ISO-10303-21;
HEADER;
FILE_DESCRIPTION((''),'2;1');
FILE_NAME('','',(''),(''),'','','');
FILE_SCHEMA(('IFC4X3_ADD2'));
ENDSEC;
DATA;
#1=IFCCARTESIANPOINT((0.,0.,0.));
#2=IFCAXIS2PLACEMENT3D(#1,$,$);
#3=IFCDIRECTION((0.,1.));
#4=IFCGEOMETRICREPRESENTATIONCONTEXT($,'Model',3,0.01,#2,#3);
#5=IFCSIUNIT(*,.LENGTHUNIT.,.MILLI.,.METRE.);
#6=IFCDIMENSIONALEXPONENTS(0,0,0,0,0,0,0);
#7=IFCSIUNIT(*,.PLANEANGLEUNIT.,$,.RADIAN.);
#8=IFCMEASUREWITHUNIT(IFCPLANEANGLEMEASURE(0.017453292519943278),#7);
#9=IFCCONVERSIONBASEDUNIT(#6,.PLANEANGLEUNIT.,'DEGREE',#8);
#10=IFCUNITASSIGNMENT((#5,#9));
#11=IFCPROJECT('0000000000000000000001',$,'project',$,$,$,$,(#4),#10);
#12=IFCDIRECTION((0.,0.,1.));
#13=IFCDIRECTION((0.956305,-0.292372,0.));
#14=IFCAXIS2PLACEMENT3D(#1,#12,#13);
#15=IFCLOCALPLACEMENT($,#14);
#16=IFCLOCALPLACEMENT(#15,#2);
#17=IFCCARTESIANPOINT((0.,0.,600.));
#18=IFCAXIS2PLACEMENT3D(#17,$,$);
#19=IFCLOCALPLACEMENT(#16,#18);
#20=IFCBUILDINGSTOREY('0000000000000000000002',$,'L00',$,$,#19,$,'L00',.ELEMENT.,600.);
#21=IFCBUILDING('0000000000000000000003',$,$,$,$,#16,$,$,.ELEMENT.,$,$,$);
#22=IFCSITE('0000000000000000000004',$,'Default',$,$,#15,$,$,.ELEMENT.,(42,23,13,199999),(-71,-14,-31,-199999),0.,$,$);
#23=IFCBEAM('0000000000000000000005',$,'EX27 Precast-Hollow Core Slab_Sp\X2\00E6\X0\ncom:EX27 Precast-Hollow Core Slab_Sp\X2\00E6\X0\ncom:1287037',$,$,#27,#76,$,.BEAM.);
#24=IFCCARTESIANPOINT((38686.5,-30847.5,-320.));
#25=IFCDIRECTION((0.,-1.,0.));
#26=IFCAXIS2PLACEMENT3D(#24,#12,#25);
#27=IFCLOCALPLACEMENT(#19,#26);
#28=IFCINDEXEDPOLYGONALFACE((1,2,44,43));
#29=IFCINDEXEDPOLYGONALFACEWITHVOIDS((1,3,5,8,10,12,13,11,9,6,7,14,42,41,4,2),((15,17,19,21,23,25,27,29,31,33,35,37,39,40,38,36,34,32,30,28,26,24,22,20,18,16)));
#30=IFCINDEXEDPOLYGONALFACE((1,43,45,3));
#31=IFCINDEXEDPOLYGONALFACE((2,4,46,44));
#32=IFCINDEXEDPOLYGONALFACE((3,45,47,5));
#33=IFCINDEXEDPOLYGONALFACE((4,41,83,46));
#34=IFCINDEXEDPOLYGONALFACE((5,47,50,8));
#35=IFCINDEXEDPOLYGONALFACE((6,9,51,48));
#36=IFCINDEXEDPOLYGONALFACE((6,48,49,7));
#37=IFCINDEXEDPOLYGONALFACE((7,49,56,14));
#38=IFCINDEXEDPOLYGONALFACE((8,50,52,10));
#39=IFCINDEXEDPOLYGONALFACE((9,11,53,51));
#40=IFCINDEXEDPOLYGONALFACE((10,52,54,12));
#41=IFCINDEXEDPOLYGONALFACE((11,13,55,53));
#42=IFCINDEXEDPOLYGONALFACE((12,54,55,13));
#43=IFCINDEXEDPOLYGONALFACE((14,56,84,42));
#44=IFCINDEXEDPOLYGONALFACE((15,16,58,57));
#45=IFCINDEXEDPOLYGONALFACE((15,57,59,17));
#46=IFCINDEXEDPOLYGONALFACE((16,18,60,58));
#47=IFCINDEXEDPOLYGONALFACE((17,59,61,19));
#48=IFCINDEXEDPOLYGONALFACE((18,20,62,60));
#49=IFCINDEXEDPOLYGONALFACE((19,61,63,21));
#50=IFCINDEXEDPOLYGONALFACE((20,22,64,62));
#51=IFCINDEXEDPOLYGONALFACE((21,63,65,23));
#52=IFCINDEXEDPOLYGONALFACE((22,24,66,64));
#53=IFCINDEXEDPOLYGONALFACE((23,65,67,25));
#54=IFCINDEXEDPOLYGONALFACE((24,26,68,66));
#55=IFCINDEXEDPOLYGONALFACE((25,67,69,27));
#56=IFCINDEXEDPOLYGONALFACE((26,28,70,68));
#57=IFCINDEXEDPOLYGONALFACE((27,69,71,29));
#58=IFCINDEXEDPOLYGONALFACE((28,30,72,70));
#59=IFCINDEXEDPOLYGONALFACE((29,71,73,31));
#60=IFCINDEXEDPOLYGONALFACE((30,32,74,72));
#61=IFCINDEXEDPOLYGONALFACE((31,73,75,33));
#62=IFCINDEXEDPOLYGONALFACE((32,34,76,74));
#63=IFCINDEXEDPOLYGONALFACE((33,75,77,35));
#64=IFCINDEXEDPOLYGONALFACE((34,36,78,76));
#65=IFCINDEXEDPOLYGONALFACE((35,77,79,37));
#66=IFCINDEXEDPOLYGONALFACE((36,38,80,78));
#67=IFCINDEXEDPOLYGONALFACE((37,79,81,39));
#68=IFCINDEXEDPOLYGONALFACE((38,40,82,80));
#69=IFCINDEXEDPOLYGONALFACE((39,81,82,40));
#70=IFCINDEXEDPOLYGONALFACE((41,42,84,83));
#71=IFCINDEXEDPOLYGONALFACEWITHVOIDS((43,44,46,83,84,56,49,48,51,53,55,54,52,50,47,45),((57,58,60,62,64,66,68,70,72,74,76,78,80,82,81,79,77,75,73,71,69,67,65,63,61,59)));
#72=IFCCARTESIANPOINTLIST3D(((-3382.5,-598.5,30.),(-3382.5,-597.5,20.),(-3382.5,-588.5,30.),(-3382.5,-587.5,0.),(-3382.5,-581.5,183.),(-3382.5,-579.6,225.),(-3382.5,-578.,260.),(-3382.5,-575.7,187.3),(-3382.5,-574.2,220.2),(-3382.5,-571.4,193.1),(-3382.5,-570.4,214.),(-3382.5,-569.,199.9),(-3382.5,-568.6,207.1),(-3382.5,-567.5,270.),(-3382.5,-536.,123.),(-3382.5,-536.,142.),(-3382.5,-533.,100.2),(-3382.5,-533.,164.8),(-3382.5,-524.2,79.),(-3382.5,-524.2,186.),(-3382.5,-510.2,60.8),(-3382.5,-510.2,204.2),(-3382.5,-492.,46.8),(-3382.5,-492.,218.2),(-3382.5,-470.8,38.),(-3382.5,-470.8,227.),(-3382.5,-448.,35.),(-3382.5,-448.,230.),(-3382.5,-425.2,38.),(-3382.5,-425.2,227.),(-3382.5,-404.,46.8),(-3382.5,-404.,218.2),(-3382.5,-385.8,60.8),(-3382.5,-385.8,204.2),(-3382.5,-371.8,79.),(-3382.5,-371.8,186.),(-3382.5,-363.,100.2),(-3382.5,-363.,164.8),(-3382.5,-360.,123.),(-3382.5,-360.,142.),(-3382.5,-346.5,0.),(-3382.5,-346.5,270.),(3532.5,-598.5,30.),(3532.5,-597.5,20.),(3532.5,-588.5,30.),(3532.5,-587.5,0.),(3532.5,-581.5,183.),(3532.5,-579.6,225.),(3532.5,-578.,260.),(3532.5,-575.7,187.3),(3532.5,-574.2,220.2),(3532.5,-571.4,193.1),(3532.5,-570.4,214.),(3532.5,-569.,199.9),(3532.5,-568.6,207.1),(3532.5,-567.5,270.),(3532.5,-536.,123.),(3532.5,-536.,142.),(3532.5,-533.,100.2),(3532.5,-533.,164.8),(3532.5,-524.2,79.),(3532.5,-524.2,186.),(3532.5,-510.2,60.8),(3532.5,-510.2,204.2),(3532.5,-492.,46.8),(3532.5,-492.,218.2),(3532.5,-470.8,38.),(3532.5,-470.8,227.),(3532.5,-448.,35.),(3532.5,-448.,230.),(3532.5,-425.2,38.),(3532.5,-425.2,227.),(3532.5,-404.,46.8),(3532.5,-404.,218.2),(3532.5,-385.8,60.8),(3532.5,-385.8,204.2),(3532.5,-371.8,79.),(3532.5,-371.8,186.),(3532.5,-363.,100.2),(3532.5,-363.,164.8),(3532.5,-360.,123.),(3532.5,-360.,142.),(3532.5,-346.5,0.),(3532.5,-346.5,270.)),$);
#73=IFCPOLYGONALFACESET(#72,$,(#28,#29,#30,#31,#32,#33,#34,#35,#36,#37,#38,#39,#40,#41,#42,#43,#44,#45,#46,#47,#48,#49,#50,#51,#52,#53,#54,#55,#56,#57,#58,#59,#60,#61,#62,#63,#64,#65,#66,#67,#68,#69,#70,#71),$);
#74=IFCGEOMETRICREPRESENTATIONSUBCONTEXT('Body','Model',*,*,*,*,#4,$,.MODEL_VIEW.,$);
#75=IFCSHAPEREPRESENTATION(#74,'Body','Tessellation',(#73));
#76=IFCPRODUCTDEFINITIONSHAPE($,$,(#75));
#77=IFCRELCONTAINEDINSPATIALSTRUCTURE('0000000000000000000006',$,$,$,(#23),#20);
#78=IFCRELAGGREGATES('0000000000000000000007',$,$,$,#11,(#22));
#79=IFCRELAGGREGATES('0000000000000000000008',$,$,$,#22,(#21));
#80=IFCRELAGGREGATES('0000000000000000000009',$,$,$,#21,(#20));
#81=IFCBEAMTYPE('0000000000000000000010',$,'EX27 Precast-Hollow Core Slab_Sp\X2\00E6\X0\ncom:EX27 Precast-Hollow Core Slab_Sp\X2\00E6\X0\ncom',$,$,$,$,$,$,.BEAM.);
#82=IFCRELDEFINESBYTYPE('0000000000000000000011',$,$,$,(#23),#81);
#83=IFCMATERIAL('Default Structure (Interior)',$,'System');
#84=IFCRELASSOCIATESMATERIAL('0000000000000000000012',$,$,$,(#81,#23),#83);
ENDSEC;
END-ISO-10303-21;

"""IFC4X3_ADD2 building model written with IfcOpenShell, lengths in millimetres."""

from ifc_helpers import new_model, entity, si_unit, converted_unit, direction, frame, frame_2d, origin, place, context, subcontext, project, spatial, polyline, circle_curve, parameter, trimmed, segment, composite_curve, outline, extrude, source, transform, mapped, material, material_profile, profile_set, profile_usage, type_object, type_shapes, element, save


model = new_model("IFC4X3_ADD2")

# Units and contexts
model_context = context("Model", 3, precision=0.01, world=origin(), true_north=direction((0.0, 1.0)))
body_context = subcontext(model_context, "Body", "Model", "MODEL_VIEW")
ifc_project = project(units=[si_unit("LENGTHUNIT", "METRE", prefix="MILLI"), converted_unit("PLANEANGLEUNIT", "DEGREE", entity("IfcPlaneAngleMeasure", 0.017453292519943278), si_unit("PLANEANGLEUNIT", "RADIAN"), dimensions=[0, 0, 0, 0, 0, 0, 0])], contexts=[model_context])

# Site, building, storey
site_placement = place(None, frame((0.0, 0.0, 0.0), z_axis=(0.0, 0.0, 1.0), x_axis=(0.956305, -0.292372, 0.0)))
site = spatial("IfcSite", under=ifc_project, at=site_placement, Name="Default", CompositionType="ELEMENT", RefLatitude=(42, 23, 13, 199999), RefLongitude=(-71, -14, -31, -199999), RefElevation=0.0)
building_placement = place(site_placement, origin())
building = spatial("IfcBuilding", under=site, at=building_placement, CompositionType="ELEMENT")
storey_placement = place(building_placement, frame((0.0, 0.0, 600.0)))
storey = spatial("IfcBuildingStorey", under=building, at=storey_placement, Name="L00", LongName="L00", CompositionType="ELEMENT", Elevation=600.0)

# Beam
ifc_material_1 = material(Name="Default Structure (Interior)", Category="System")
ifc_material_profile_1 = material_profile(ifc_material_1, outline(composite_curve([segment(polyline([(-124.1, 583.4), (-124.6, 593.4)]), True, "CONTINUOUS"), segment(polyline([(-124.6, 593.4), (-134.5, 592.0)]), True, "CONTINUOUS"), segment(polyline([(-134.5, 592.0), (-154.0, 581.1)]), True, "CONTINUOUS"), segment(polyline([(-154.0, 581.1), (-100.2, -592.7)]), True, "CONTINUOUS"), segment(polyline([(-100.2, -592.7), (-79.8, -601.8)]), True, "CONTINUOUS"), segment(polyline([(-79.8, -601.8), (-69.7, -602.3)]), True, "CONTINUOUS"), segment(polyline([(-69.7, -602.3), (-70.2, -592.3)]), True, "CONTINUOUS"), segment(polyline([(-70.2, -592.3), (82.3, -578.3)]), True, "CONTINUOUS"), segment(trimmed(circle_curve(frame_2d((104.4, -588.8), x_axis=(0.045785, -0.998951)), 24.4), [parameter(123.160759)], [parameter(242.087681)], True, "PARAMETER"), False, "CONTINUOUS"), segment(polyline([(124.2, -574.5), (159.1, -571.3)]), True, "CONTINUOUS"), segment(polyline([(159.1, -571.3), (168.6, -560.4)]), True, "CONTINUOUS"), segment(polyline([(168.6, -560.4), (116.6, 573.4)]), True, "CONTINUOUS"), segment(polyline([(116.6, 573.4), (106.2, 583.4)]), True, "CONTINUOUS"), segment(polyline([(106.2, 583.4), (71.1, 583.4)]), True, "CONTINUOUS"), segment(trimmed(circle_curve(frame_2d((50.1, 595.8), x_axis=(0.045785, -0.998951)), 24.4), [parameter(297.912319)], [parameter(56.839241)], True, "PARAMETER"), False, "CONTINUOUS"), segment(polyline([(29.1, 583.4), (-124.1, 583.4)]), True, "CONTINUOUS")], self_intersect=False), holes=[composite_curve([segment(polyline([(39.3, -534.8), (20.3, -535.6)]), True, "CONTINUOUS"), segment(trimmed(circle_curve(frame_2d((16.3, -447.7), x_axis=(0.045785, -0.998951)), 88.0), [parameter(270.0)], [parameter(0.0)], True, "PARAMETER"), False, "CONTINUOUS"), segment(trimmed(circle_curve(frame_2d((16.3, -447.7), x_axis=(0.045785, -0.998951)), 88.0), [parameter(180.0)], [parameter(270.0)], True, "PARAMETER"), False, "CONTINUOUS"), segment(polyline([(12.2, -359.8), (31.2, -358.9)]), True, "CONTINUOUS"), segment(trimmed(circle_curve(frame_2d((35.2, -446.9), x_axis=(0.045785, -0.998951)), 88.0), [parameter(90.0)], [parameter(180.0)], True, "PARAMETER"), False, "CONTINUOUS"), segment(trimmed(circle_curve(frame_2d((35.2, -446.9), x_axis=(0.045785, -0.998951)), 88.0), [parameter(0.0)], [parameter(90.0)], True, "PARAMETER"), False, "CONTINUOUS")], self_intersect=False), composite_curve([segment(trimmed(circle_curve(frame_2d((6.0, -224.0), x_axis=(0.045785, -0.998951)), 88.0), [parameter(180.0)], [parameter(270.0)], True, "PARAMETER"), False, "CONTINUOUS"), segment(polyline([(2.0, -136.1), (21.0, -135.2)]), True, "CONTINUOUS"), segment(trimmed(circle_curve(frame_2d((25.0, -223.1), x_axis=(0.045785, -0.998951)), 88.0), [parameter(90.0)], [parameter(180.0)], True, "PARAMETER"), False, "CONTINUOUS"), segment(trimmed(circle_curve(frame_2d((25.0, -223.1), x_axis=(0.045785, -0.998951)), 88.0), [parameter(0.0)], [parameter(90.0)], True, "PARAMETER"), False, "CONTINUOUS"), segment(polyline([(29.0, -311.0), (10.0, -311.9)]), True, "CONTINUOUS"), segment(trimmed(circle_curve(frame_2d((6.0, -224.0), x_axis=(0.045785, -0.998951)), 88.0), [parameter(270.0)], [parameter(0.0)], True, "PARAMETER"), False, "CONTINUOUS")], self_intersect=False), composite_curve([segment(trimmed(circle_curve(frame_2d((-4.2, -0.2), x_axis=(0.045785, -0.998951)), 88.0), [parameter(180.0)], [parameter(270.0)], True, "PARAMETER"), False, "CONTINUOUS"), segment(polyline([(-8.3, 87.7), (10.7, 88.6)]), True, "CONTINUOUS"), segment(trimmed(circle_curve(frame_2d((14.7, 0.7), x_axis=(0.045785, -0.998951)), 88.0), [parameter(90.0)], [parameter(180.0)], True, "PARAMETER"), False, "CONTINUOUS"), segment(trimmed(circle_curve(frame_2d((14.7, 0.7), x_axis=(0.045785, -0.998951)), 88.0), [parameter(0.0)], [parameter(90.0)], True, "PARAMETER"), False, "CONTINUOUS"), segment(polyline([(18.8, -87.2), (-0.2, -88.1)]), True, "CONTINUOUS"), segment(trimmed(circle_curve(frame_2d((-4.2, -0.2), x_axis=(0.045785, -0.998951)), 88.0), [parameter(270.0)], [parameter(0.0)], True, "PARAMETER"), False, "CONTINUOUS")], self_intersect=False), composite_curve([segment(trimmed(circle_curve(frame_2d((-14.5, 223.6), x_axis=(0.045785, -0.998951)), 88.0), [parameter(180.0)], [parameter(270.0)], True, "PARAMETER"), False, "CONTINUOUS"), segment(polyline([(-18.5, 311.5), (0.4, 312.3)]), True, "CONTINUOUS"), segment(trimmed(circle_curve(frame_2d((4.5, 224.4), x_axis=(0.045785, -0.998951)), 88.0), [parameter(90.0)], [parameter(180.0)], True, "PARAMETER"), False, "CONTINUOUS"), segment(trimmed(circle_curve(frame_2d((4.5, 224.4), x_axis=(0.045785, -0.998951)), 88.0), [parameter(0.0)], [parameter(90.0)], True, "PARAMETER"), False, "CONTINUOUS"), segment(polyline([(8.5, 136.5), (-10.5, 135.7)]), True, "CONTINUOUS"), segment(trimmed(circle_curve(frame_2d((-14.5, 223.6), x_axis=(0.045785, -0.998951)), 88.0), [parameter(270.0)], [parameter(0.0)], True, "PARAMETER"), False, "CONTINUOUS")], self_intersect=False), composite_curve([segment(trimmed(circle_curve(frame_2d((-24.8, 447.3), x_axis=(0.045785, -0.998951)), 88.0), [parameter(180.0)], [parameter(270.0)], True, "PARAMETER"), False, "CONTINUOUS"), segment(polyline([(-28.8, 535.2), (-9.8, 536.1)]), True, "CONTINUOUS"), segment(trimmed(circle_curve(frame_2d((-5.8, 448.2), x_axis=(0.045785, -0.998951)), 88.0), [parameter(90.0)], [parameter(180.0)], True, "PARAMETER"), False, "CONTINUOUS"), segment(trimmed(circle_curve(frame_2d((-5.8, 448.2), x_axis=(0.045785, -0.998951)), 88.0), [parameter(0.0)], [parameter(90.0)], True, "PARAMETER"), False, "CONTINUOUS"), segment(polyline([(-1.7, 360.3), (-20.7, 359.4)]), True, "CONTINUOUS"), segment(trimmed(circle_curve(frame_2d((-24.8, 447.3), x_axis=(0.045785, -0.998951)), 88.0), [parameter(270.0)], [parameter(0.0)], True, "PARAMETER"), False, "CONTINUOUS")], self_intersect=False)]), Name="EX27 Precast-Hollow Core Slab_Spæncom")
ifc_profile_set_1 = profile_set([ifc_material_profile_1], Name="EX27 Precast-Hollow Core Slab_Spæncom")
ifc_profile_usage_1 = profile_usage(ifc_profile_set_1, cardinal=8)
beam_type_1 = type_object("IfcBeamType", Name="EX27 Precast-Hollow Core Slab_Spæncom:EX27 Precast-Hollow Core Slab_Spæncom", PredefinedType="BEAM", material=ifc_profile_set_1)
shared_shape_1 = source(origin(), body_context, "Body", "SweptSolid", [
    extrude(outline(composite_curve([segment(polyline([(-50.3, -128.8), (190.7, -128.8)]), True, "CONTINUOUS"), segment(polyline([(190.7, -128.8), (190.7, 141.2)]), True, "CONTINUOUS"), segment(polyline([(190.7, 141.2), (-30.3, 141.2)]), True, "CONTINUOUS"), segment(polyline([(-30.3, 141.2), (-40.8, 131.2)]), True, "CONTINUOUS"), segment(polyline([(-40.8, 131.2), (-42.4, 96.2)]), True, "CONTINUOUS"), segment(trimmed(circle_curve(frame_2d((-55.8, 75.8), x_axis=(-1.0, 0.0)), 24.4), [parameter(117.912319)], [parameter(236.839241)], True, "PARAMETER"), False, "CONTINUOUS"), segment(polyline([(-44.3, 54.2), (-51.3, -98.8)]), True, "CONTINUOUS"), segment(polyline([(-51.3, -98.8), (-61.3, -98.8)]), True, "CONTINUOUS"), segment(polyline([(-61.3, -98.8), (-60.3, -108.8)]), True, "CONTINUOUS"), segment(polyline([(-60.3, -108.8), (-50.3, -128.8)]), True, "CONTINUOUS")], self_intersect=False), holes=[composite_curve([segment(trimmed(circle_curve(frame_2d((89.2, 13.2), x_axis=(-1.0, 0.0)), 88.0), [parameter(270.0)], [parameter(0.0)], True, "PARAMETER"), False, "CONTINUOUS"), segment(trimmed(circle_curve(frame_2d((89.2, 13.2), x_axis=(-1.0, 0.0)), 88.0), [parameter(180.0)], [parameter(270.0)], True, "PARAMETER"), False, "CONTINUOUS"), segment(polyline([(177.2, 13.2), (177.2, -5.8)]), True, "CONTINUOUS"), segment(trimmed(circle_curve(frame_2d((89.2, -5.8), x_axis=(-1.0, 0.0)), 88.0), [parameter(90.0)], [parameter(180.0)], True, "PARAMETER"), False, "CONTINUOUS"), segment(trimmed(circle_curve(frame_2d((89.2, -5.8), x_axis=(-1.0, 0.0)), 88.0), [parameter(0.0)], [parameter(90.0)], True, "PARAMETER"), False, "CONTINUOUS"), segment(polyline([(1.2, -5.8), (1.2, 13.2)]), True, "CONTINUOUS")], self_intersect=False)]), frame((-3382.5, -537.2, 128.8), z_axis=(1.0, 0.0, 0.0), x_axis=(0.0, 1.0, 0.0)), (0.0, 0.0, 1.0), 6915.0),
])
type_shapes(beam_type_1, [shared_shape_1])
beam_1_placement = place(storey_placement, frame((38686.5, -30847.5, -320.0), z_axis=(0.0, 0.0, 1.0), x_axis=(0.0, -1.0, 0.0)))
element("IfcBeam", 1, at=beam_1_placement, inside=storey, type_object=beam_type_1, material=ifc_profile_usage_1, Name="EX27 Precast-Hollow Core Slab_Spæncom:EX27 Precast-Hollow Core Slab_Spæncom:1287037", PredefinedType="BEAM", context=body_context, shape_type="MappedRepresentation", body=[
    mapped(shared_shape_1, transform((0.0, 0.0, 0.0), scale=1.0)),
])

save(model, "model.ifc")
